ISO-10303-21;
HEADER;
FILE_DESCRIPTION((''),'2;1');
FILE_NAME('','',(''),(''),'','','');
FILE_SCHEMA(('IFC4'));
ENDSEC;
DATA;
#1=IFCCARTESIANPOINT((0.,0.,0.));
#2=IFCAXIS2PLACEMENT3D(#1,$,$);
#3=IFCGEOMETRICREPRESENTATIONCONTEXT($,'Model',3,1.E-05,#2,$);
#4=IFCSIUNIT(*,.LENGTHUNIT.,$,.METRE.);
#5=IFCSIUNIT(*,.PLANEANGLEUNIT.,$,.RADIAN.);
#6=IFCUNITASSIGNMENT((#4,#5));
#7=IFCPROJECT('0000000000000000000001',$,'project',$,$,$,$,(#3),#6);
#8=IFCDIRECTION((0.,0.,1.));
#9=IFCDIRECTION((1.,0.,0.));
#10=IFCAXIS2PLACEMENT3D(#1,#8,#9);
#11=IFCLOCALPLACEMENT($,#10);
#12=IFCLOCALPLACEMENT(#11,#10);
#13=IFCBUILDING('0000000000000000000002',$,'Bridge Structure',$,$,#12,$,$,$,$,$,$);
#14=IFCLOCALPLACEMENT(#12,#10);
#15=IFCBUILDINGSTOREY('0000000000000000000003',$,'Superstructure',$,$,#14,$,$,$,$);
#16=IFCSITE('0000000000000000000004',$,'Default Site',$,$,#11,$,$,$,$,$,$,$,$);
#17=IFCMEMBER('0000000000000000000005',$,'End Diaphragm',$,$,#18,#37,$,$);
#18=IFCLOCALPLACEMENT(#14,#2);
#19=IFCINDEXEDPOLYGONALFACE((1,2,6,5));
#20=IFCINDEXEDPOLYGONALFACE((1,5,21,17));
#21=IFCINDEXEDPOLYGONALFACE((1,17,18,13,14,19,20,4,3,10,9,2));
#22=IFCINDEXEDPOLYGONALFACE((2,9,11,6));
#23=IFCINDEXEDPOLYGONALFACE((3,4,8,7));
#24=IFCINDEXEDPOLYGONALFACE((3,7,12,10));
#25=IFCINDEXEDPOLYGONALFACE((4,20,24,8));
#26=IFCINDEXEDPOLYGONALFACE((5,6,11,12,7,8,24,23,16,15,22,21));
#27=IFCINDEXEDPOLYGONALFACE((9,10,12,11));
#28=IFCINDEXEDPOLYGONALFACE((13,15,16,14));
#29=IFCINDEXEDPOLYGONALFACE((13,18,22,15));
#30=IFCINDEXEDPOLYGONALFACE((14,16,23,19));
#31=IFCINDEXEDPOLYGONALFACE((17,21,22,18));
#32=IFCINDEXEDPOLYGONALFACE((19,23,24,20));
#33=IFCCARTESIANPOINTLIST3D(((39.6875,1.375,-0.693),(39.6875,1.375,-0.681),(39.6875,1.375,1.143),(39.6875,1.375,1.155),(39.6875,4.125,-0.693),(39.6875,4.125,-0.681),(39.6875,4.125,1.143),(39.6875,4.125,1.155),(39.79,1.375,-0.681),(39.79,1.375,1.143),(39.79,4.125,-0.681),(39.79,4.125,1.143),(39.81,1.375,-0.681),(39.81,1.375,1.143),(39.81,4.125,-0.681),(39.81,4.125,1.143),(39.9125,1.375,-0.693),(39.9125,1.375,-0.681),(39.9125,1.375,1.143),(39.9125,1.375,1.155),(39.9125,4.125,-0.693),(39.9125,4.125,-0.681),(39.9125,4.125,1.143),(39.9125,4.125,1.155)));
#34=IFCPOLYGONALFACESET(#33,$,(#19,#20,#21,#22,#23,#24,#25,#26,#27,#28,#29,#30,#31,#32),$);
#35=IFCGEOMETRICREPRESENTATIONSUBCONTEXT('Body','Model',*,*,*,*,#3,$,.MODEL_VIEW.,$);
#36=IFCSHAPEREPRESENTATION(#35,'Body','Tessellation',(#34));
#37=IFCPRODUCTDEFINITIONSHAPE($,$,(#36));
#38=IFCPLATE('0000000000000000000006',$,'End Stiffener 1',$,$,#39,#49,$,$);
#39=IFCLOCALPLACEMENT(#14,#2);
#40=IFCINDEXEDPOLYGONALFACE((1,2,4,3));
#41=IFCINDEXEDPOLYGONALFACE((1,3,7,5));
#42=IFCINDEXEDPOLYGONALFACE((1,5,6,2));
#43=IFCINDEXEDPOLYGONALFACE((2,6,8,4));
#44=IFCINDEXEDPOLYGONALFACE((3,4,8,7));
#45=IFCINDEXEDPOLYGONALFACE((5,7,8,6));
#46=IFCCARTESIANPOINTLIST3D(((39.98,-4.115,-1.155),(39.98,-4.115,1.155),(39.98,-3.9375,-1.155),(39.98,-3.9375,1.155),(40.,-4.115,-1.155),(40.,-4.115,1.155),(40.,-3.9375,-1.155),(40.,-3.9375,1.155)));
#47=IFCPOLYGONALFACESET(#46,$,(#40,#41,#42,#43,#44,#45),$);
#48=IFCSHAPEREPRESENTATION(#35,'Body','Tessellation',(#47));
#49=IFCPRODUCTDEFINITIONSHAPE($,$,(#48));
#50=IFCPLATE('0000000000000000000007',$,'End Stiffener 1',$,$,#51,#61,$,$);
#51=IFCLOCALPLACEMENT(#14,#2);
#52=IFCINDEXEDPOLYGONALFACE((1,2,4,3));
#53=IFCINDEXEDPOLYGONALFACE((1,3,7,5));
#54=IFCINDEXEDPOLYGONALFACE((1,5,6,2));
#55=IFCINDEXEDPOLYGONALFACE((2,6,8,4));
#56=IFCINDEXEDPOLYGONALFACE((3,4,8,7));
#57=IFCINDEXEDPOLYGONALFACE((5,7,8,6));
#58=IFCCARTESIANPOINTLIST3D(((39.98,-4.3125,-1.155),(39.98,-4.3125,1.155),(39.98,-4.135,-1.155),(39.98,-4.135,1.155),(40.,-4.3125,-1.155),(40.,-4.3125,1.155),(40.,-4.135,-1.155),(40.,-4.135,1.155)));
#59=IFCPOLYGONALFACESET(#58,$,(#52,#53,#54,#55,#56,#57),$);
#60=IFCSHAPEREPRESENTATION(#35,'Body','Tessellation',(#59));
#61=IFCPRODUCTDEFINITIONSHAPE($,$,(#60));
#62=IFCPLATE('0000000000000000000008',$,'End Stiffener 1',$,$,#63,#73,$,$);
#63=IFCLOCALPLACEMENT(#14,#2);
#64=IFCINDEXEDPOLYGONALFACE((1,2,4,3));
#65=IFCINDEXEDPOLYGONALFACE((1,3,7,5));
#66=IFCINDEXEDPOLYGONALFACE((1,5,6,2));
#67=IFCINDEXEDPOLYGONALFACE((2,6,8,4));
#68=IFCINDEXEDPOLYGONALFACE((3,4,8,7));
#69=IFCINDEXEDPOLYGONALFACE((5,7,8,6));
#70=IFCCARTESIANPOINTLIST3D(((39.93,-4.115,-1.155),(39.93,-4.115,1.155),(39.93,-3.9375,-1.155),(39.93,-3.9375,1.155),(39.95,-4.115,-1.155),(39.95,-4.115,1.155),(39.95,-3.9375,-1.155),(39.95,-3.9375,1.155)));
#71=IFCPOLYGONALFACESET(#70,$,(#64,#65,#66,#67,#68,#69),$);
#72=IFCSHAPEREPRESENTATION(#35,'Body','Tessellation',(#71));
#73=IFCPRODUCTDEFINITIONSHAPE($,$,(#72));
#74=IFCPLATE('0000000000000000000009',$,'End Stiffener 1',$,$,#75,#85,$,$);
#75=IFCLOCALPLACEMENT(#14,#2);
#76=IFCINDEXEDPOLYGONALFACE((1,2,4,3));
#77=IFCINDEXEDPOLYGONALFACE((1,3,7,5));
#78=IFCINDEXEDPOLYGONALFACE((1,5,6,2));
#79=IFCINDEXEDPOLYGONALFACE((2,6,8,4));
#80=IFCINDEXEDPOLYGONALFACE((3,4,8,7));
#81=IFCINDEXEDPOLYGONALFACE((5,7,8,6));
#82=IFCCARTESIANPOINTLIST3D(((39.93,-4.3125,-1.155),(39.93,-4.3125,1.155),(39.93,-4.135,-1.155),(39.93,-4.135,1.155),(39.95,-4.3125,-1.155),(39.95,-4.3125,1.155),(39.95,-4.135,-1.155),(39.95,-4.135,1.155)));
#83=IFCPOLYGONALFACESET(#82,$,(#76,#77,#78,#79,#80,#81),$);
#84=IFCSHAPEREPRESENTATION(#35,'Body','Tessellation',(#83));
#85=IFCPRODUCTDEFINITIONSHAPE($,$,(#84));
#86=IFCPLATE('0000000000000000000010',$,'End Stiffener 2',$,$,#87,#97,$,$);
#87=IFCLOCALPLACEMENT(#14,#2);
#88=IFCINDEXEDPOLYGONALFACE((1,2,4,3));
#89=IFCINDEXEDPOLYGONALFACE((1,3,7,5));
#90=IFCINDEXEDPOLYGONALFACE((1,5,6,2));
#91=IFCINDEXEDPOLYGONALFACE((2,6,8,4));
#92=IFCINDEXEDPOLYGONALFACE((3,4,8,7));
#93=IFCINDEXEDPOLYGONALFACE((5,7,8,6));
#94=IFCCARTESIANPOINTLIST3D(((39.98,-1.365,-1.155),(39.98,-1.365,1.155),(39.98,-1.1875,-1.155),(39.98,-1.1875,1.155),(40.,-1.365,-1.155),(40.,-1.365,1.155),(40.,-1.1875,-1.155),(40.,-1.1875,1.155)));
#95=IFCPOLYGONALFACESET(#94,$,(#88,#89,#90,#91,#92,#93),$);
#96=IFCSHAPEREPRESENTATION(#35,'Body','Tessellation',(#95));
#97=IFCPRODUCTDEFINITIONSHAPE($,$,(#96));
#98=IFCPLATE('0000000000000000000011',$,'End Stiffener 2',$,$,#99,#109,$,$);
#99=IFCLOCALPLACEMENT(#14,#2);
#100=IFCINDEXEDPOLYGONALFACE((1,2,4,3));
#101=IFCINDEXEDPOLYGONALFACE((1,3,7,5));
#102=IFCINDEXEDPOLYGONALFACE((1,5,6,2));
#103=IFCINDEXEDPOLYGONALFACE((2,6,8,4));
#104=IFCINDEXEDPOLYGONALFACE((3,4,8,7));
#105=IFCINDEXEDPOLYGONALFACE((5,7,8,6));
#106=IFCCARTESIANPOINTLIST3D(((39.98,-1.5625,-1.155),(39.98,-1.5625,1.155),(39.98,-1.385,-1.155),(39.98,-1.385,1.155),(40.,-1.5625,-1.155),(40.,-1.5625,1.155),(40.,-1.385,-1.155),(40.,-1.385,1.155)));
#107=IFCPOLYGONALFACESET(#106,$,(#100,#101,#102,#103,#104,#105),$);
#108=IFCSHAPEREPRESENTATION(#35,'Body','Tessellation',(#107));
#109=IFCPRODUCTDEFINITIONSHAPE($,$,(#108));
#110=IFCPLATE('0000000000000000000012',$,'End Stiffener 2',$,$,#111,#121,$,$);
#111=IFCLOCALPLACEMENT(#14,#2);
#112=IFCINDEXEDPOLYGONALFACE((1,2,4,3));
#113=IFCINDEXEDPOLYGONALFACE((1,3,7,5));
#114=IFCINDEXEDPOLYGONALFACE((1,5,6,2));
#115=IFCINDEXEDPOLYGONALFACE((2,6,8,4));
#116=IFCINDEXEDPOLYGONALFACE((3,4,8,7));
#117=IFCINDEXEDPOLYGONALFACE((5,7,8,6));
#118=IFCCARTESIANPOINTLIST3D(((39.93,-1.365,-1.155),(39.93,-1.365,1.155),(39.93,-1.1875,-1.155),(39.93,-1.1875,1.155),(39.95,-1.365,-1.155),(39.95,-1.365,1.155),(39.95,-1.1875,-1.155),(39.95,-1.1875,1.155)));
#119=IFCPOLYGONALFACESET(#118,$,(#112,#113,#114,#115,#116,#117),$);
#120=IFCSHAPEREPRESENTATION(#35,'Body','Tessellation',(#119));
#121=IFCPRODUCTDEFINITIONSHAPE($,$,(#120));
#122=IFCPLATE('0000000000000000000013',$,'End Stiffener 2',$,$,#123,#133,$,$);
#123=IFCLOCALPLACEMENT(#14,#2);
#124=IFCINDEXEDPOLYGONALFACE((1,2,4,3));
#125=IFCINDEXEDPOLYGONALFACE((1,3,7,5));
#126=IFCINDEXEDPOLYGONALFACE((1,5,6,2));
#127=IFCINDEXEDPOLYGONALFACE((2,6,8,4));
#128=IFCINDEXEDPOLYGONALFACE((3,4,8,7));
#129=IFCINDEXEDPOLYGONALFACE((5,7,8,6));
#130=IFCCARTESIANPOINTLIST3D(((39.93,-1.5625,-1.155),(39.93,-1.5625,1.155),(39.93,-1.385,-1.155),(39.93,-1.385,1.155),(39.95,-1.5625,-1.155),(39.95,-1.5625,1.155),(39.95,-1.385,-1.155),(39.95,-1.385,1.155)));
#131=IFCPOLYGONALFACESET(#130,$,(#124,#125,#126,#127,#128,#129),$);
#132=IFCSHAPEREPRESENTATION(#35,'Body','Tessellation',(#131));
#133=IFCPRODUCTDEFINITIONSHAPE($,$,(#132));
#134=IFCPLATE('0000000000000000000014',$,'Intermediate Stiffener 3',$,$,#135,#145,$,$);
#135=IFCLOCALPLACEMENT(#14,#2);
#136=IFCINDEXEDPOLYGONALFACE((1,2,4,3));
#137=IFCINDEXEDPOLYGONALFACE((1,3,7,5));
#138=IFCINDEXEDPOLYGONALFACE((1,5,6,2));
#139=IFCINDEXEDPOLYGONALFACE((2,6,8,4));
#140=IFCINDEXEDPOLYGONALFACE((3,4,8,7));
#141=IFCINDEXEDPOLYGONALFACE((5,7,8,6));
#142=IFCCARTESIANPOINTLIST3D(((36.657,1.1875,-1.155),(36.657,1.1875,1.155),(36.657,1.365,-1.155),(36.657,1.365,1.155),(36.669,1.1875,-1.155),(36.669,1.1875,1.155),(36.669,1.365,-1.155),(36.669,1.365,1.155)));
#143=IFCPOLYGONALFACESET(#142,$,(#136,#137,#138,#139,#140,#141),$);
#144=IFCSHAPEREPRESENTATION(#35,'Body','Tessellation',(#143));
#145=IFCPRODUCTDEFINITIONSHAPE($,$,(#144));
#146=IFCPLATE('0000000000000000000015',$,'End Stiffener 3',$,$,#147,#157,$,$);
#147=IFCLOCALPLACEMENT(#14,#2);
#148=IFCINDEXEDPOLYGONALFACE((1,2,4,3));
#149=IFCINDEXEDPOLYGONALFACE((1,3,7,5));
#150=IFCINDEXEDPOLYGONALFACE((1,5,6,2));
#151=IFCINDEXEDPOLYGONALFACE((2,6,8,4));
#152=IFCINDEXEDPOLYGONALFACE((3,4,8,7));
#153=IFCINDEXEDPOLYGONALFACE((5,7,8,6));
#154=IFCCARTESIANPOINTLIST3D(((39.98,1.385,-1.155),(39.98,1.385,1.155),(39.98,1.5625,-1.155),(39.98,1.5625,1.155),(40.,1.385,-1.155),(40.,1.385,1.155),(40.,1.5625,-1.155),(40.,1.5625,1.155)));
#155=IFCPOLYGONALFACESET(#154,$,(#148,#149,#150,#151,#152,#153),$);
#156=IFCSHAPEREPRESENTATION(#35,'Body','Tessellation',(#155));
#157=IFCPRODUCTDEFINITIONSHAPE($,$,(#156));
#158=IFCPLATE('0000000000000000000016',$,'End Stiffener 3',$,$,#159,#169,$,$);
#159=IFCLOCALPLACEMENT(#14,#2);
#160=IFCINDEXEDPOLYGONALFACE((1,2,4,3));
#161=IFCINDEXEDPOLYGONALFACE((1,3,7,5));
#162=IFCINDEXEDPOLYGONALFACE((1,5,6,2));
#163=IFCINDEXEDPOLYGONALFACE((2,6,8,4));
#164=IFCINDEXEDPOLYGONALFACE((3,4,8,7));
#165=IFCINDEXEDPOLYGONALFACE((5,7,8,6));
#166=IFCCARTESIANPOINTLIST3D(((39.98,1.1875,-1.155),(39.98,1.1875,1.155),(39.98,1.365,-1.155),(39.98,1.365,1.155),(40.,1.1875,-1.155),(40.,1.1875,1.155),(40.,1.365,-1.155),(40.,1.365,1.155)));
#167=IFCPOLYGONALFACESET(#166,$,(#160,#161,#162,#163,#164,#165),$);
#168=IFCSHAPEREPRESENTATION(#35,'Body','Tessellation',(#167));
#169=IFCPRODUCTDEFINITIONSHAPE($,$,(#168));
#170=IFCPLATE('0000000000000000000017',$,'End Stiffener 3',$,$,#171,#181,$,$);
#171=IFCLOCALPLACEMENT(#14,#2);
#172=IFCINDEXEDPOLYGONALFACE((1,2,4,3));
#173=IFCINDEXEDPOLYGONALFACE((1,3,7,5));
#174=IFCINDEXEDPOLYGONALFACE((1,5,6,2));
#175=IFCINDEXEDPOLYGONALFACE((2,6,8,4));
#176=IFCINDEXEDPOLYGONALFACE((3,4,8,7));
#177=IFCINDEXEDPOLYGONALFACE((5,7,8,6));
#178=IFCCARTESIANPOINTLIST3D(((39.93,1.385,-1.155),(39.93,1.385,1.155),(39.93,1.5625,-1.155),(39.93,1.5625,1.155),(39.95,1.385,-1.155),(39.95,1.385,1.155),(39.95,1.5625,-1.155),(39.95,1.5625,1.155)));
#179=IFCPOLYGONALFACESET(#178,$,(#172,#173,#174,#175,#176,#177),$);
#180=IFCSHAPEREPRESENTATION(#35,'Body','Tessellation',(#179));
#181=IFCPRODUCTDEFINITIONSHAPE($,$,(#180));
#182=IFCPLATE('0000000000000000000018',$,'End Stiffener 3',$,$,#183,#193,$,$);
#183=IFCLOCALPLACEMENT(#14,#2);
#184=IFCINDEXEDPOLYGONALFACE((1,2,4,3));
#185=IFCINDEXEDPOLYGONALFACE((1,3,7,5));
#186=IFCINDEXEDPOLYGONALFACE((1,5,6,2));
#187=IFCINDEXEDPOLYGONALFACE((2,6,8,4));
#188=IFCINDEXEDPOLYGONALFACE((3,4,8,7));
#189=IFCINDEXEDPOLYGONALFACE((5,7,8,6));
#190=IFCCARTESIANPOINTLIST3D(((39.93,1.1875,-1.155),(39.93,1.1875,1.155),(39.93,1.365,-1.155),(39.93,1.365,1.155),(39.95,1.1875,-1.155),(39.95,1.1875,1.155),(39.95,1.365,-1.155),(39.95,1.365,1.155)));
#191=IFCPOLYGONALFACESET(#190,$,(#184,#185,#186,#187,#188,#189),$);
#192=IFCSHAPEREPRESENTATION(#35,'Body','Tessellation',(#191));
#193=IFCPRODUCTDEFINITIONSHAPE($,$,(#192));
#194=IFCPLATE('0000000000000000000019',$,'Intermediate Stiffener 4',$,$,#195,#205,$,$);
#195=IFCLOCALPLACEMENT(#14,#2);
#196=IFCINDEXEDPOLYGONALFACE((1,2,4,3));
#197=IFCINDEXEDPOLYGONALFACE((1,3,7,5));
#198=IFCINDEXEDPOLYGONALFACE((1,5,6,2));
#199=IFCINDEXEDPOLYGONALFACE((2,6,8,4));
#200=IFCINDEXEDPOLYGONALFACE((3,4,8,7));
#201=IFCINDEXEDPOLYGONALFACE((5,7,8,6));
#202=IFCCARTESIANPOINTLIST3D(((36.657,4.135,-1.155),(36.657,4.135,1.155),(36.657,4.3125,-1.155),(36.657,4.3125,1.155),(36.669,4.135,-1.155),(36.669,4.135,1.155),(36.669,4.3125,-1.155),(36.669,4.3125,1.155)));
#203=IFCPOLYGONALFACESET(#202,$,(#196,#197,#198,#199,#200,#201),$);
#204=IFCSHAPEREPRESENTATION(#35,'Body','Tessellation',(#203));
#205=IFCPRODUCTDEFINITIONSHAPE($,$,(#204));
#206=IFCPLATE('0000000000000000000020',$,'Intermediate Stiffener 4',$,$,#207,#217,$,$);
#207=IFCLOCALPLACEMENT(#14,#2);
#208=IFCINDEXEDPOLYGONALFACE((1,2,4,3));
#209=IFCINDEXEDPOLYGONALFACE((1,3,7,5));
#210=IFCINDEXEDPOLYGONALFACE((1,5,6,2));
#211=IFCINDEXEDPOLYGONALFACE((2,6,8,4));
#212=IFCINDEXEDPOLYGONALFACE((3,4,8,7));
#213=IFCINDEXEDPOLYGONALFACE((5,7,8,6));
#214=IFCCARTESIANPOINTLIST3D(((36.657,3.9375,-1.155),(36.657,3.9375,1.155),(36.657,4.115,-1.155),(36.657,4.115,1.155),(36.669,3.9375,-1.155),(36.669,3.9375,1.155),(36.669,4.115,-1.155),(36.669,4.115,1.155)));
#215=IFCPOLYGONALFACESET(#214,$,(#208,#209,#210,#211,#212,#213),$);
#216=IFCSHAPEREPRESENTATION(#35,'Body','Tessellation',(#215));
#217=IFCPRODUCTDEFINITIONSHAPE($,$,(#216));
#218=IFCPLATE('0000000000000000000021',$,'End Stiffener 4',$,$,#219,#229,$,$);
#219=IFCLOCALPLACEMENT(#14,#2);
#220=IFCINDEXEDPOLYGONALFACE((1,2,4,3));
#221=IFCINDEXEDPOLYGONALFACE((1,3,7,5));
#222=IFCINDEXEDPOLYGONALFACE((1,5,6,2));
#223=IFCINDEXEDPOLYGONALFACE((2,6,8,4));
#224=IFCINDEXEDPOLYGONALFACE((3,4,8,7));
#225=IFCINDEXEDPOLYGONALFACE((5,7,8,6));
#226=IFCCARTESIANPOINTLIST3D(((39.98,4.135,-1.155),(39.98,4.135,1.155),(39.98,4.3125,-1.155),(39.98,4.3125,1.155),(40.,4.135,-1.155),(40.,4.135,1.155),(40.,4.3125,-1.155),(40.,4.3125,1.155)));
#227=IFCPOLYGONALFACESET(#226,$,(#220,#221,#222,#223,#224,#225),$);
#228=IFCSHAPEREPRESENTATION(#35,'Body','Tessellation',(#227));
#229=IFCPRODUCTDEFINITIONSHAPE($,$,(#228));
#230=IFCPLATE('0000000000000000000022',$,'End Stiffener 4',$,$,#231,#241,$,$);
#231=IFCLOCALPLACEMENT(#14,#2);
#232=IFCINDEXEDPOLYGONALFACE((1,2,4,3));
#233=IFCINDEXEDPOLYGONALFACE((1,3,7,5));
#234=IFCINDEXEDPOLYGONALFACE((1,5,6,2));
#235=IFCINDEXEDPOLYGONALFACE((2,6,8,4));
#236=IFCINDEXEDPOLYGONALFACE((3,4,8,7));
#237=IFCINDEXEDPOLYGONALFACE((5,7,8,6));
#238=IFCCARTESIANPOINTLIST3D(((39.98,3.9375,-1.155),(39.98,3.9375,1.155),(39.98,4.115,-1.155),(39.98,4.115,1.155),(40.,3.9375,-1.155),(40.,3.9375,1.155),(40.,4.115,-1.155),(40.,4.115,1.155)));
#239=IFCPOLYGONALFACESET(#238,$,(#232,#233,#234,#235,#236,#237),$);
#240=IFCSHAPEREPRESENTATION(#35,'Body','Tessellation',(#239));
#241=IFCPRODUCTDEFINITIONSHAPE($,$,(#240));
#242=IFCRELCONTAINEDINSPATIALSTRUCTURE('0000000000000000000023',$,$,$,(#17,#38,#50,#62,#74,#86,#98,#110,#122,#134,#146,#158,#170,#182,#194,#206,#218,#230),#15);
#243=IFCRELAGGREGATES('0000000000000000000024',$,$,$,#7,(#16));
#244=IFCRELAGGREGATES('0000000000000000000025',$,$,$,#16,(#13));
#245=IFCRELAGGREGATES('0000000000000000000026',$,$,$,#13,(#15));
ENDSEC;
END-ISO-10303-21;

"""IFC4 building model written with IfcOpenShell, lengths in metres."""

from ifc_helpers import new_model, si_unit, frame, origin, origin_with_axes, origin_2d_with_axis, place, context, subcontext, project, spatial, rectangle, i_section, extrude, element, save


model = new_model("IFC4")

# Units and contexts
model_context = context("Model", 3, precision=1e-05, world=origin())
body_context = subcontext(model_context, "Body", "Model", "MODEL_VIEW")
ifc_project = project(units=[si_unit("LENGTHUNIT", "METRE"), si_unit("PLANEANGLEUNIT", "RADIAN")], contexts=[model_context])

# Site, building, storey
site_placement = place(None, origin_with_axes())
site = spatial("IfcSite", under=ifc_project, at=site_placement, Name="Default Site")
building_placement = place(site_placement, origin_with_axes())
building = spatial("IfcBuilding", under=site, at=building_placement, Name="Bridge Structure")
storey_placement = place(building_placement, origin_with_axes())
storey = spatial("IfcBuildingStorey", under=building, at=storey_placement, Name="Superstructure")

# Member
for number, where, z_axis, x_axis, name in (
    (1, (39.8, 1.375, 0.231), (0.0, 1.0, 0.0), (-1.0, 0.0, 0.0), "End Diaphragm"),
):
    element("IfcMember", number, at=place(storey_placement, frame(where, z_axis=z_axis, x_axis=x_axis)), inside=storey, Name=name, context=body_context, shape_type="SweptSolid", body=[
        extrude(i_section(OverallWidth=0.225, OverallDepth=1.848, WebThickness=0.02, FlangeThickness=0.012, at=origin_2d_with_axis()), origin_with_axes(), (0.0, 0.0, 1.0), 2.75),
    ])

# Plates
for number, where, z_axis, x_axis, name in (
    (2, (39.99, -4.0263, -1.155), (0.0, 0.0, 1.0), (1.0, 0.0, 0.0), "End Stiffener 1"),
    (3, (39.99, -4.2237, -1.155), (0.0, 0.0, 1.0), (1.0, 0.0, 0.0), "End Stiffener 1"),
    (4, (39.94, -4.0263, -1.155), (0.0, 0.0, 1.0), (1.0, 0.0, 0.0), "End Stiffener 1"),
    (5, (39.94, -4.2237, -1.155), (0.0, 0.0, 1.0), (1.0, 0.0, 0.0), "End Stiffener 1"),
    (6, (39.99, -1.2763, -1.155), (0.0, 0.0, 1.0), (1.0, 0.0, 0.0), "End Stiffener 2"),
    (7, (39.99, -1.4738, -1.155), (0.0, 0.0, 1.0), (1.0, 0.0, 0.0), "End Stiffener 2"),
    (8, (39.94, -1.2763, -1.155), (0.0, 0.0, 1.0), (1.0, 0.0, 0.0), "End Stiffener 2"),
    (9, (39.94, -1.4738, -1.155), (0.0, 0.0, 1.0), (1.0, 0.0, 0.0), "End Stiffener 2"),
):
    element("IfcPlate", number, at=place(storey_placement, frame(where, z_axis=z_axis, x_axis=x_axis)), inside=storey, Name=name, context=body_context, shape_type="SweptSolid", body=[
        extrude(rectangle(XDim=0.02, YDim=0.1775, at=origin_2d_with_axis()), origin_with_axes(), (0.0, 0.0, 1.0), 2.31),
    ])
plate_placement = place(storey_placement, frame((36.663, 1.2763, -1.155), z_axis=(0.0, 0.0, 1.0), x_axis=(1.0, 0.0, 0.0)))
element("IfcPlate", 10, at=plate_placement, inside=storey, Name="Intermediate Stiffener 3", context=body_context, shape_type="SweptSolid", body=[
    extrude(rectangle(XDim=0.012, YDim=0.1775, at=origin_2d_with_axis()), origin_with_axes(), (0.0, 0.0, 1.0), 2.31),
])
for number, where, z_axis, x_axis, name in (
    (11, (39.99, 1.4738, -1.155), (0.0, 0.0, 1.0), (1.0, 0.0, 0.0), "End Stiffener 3"),
    (12, (39.99, 1.2763, -1.155), (0.0, 0.0, 1.0), (1.0, 0.0, 0.0), "End Stiffener 3"),
    (13, (39.94, 1.4738, -1.155), (0.0, 0.0, 1.0), (1.0, 0.0, 0.0), "End Stiffener 3"),
    (14, (39.94, 1.2763, -1.155), (0.0, 0.0, 1.0), (1.0, 0.0, 0.0), "End Stiffener 3"),
):
    element("IfcPlate", number, at=place(storey_placement, frame(where, z_axis=z_axis, x_axis=x_axis)), inside=storey, Name=name, context=body_context, shape_type="SweptSolid", body=[
        extrude(rectangle(XDim=0.02, YDim=0.1775, at=origin_2d_with_axis()), origin_with_axes(), (0.0, 0.0, 1.0), 2.31),
    ])
for number, where, z_axis, x_axis, name in (
    (15, (36.663, 4.2237, -1.155), (0.0, 0.0, 1.0), (1.0, 0.0, 0.0), "Intermediate Stiffener 4"),
    (16, (36.663, 4.0263, -1.155), (0.0, 0.0, 1.0), (1.0, 0.0, 0.0), "Intermediate Stiffener 4"),
):
    element("IfcPlate", number, at=place(storey_placement, frame(where, z_axis=z_axis, x_axis=x_axis)), inside=storey, Name=name, context=body_context, shape_type="SweptSolid", body=[
        extrude(rectangle(XDim=0.012, YDim=0.1775, at=origin_2d_with_axis()), origin_with_axes(), (0.0, 0.0, 1.0), 2.31),
    ])
for number, where, z_axis, x_axis, name in (
    (17, (39.99, 4.2237, -1.155), (0.0, 0.0, 1.0), (1.0, 0.0, 0.0), "End Stiffener 4"),
    (18, (39.99, 4.0263, -1.155), (0.0, 0.0, 1.0), (1.0, 0.0, 0.0), "End Stiffener 4"),
):
    element("IfcPlate", number, at=place(storey_placement, frame(where, z_axis=z_axis, x_axis=x_axis)), inside=storey, Name=name, context=body_context, shape_type="SweptSolid", body=[
        extrude(rectangle(XDim=0.02, YDim=0.1775, at=origin_2d_with_axis()), origin_with_axes(), (0.0, 0.0, 1.0), 2.31),
    ])

save(model, "model.ifc")
